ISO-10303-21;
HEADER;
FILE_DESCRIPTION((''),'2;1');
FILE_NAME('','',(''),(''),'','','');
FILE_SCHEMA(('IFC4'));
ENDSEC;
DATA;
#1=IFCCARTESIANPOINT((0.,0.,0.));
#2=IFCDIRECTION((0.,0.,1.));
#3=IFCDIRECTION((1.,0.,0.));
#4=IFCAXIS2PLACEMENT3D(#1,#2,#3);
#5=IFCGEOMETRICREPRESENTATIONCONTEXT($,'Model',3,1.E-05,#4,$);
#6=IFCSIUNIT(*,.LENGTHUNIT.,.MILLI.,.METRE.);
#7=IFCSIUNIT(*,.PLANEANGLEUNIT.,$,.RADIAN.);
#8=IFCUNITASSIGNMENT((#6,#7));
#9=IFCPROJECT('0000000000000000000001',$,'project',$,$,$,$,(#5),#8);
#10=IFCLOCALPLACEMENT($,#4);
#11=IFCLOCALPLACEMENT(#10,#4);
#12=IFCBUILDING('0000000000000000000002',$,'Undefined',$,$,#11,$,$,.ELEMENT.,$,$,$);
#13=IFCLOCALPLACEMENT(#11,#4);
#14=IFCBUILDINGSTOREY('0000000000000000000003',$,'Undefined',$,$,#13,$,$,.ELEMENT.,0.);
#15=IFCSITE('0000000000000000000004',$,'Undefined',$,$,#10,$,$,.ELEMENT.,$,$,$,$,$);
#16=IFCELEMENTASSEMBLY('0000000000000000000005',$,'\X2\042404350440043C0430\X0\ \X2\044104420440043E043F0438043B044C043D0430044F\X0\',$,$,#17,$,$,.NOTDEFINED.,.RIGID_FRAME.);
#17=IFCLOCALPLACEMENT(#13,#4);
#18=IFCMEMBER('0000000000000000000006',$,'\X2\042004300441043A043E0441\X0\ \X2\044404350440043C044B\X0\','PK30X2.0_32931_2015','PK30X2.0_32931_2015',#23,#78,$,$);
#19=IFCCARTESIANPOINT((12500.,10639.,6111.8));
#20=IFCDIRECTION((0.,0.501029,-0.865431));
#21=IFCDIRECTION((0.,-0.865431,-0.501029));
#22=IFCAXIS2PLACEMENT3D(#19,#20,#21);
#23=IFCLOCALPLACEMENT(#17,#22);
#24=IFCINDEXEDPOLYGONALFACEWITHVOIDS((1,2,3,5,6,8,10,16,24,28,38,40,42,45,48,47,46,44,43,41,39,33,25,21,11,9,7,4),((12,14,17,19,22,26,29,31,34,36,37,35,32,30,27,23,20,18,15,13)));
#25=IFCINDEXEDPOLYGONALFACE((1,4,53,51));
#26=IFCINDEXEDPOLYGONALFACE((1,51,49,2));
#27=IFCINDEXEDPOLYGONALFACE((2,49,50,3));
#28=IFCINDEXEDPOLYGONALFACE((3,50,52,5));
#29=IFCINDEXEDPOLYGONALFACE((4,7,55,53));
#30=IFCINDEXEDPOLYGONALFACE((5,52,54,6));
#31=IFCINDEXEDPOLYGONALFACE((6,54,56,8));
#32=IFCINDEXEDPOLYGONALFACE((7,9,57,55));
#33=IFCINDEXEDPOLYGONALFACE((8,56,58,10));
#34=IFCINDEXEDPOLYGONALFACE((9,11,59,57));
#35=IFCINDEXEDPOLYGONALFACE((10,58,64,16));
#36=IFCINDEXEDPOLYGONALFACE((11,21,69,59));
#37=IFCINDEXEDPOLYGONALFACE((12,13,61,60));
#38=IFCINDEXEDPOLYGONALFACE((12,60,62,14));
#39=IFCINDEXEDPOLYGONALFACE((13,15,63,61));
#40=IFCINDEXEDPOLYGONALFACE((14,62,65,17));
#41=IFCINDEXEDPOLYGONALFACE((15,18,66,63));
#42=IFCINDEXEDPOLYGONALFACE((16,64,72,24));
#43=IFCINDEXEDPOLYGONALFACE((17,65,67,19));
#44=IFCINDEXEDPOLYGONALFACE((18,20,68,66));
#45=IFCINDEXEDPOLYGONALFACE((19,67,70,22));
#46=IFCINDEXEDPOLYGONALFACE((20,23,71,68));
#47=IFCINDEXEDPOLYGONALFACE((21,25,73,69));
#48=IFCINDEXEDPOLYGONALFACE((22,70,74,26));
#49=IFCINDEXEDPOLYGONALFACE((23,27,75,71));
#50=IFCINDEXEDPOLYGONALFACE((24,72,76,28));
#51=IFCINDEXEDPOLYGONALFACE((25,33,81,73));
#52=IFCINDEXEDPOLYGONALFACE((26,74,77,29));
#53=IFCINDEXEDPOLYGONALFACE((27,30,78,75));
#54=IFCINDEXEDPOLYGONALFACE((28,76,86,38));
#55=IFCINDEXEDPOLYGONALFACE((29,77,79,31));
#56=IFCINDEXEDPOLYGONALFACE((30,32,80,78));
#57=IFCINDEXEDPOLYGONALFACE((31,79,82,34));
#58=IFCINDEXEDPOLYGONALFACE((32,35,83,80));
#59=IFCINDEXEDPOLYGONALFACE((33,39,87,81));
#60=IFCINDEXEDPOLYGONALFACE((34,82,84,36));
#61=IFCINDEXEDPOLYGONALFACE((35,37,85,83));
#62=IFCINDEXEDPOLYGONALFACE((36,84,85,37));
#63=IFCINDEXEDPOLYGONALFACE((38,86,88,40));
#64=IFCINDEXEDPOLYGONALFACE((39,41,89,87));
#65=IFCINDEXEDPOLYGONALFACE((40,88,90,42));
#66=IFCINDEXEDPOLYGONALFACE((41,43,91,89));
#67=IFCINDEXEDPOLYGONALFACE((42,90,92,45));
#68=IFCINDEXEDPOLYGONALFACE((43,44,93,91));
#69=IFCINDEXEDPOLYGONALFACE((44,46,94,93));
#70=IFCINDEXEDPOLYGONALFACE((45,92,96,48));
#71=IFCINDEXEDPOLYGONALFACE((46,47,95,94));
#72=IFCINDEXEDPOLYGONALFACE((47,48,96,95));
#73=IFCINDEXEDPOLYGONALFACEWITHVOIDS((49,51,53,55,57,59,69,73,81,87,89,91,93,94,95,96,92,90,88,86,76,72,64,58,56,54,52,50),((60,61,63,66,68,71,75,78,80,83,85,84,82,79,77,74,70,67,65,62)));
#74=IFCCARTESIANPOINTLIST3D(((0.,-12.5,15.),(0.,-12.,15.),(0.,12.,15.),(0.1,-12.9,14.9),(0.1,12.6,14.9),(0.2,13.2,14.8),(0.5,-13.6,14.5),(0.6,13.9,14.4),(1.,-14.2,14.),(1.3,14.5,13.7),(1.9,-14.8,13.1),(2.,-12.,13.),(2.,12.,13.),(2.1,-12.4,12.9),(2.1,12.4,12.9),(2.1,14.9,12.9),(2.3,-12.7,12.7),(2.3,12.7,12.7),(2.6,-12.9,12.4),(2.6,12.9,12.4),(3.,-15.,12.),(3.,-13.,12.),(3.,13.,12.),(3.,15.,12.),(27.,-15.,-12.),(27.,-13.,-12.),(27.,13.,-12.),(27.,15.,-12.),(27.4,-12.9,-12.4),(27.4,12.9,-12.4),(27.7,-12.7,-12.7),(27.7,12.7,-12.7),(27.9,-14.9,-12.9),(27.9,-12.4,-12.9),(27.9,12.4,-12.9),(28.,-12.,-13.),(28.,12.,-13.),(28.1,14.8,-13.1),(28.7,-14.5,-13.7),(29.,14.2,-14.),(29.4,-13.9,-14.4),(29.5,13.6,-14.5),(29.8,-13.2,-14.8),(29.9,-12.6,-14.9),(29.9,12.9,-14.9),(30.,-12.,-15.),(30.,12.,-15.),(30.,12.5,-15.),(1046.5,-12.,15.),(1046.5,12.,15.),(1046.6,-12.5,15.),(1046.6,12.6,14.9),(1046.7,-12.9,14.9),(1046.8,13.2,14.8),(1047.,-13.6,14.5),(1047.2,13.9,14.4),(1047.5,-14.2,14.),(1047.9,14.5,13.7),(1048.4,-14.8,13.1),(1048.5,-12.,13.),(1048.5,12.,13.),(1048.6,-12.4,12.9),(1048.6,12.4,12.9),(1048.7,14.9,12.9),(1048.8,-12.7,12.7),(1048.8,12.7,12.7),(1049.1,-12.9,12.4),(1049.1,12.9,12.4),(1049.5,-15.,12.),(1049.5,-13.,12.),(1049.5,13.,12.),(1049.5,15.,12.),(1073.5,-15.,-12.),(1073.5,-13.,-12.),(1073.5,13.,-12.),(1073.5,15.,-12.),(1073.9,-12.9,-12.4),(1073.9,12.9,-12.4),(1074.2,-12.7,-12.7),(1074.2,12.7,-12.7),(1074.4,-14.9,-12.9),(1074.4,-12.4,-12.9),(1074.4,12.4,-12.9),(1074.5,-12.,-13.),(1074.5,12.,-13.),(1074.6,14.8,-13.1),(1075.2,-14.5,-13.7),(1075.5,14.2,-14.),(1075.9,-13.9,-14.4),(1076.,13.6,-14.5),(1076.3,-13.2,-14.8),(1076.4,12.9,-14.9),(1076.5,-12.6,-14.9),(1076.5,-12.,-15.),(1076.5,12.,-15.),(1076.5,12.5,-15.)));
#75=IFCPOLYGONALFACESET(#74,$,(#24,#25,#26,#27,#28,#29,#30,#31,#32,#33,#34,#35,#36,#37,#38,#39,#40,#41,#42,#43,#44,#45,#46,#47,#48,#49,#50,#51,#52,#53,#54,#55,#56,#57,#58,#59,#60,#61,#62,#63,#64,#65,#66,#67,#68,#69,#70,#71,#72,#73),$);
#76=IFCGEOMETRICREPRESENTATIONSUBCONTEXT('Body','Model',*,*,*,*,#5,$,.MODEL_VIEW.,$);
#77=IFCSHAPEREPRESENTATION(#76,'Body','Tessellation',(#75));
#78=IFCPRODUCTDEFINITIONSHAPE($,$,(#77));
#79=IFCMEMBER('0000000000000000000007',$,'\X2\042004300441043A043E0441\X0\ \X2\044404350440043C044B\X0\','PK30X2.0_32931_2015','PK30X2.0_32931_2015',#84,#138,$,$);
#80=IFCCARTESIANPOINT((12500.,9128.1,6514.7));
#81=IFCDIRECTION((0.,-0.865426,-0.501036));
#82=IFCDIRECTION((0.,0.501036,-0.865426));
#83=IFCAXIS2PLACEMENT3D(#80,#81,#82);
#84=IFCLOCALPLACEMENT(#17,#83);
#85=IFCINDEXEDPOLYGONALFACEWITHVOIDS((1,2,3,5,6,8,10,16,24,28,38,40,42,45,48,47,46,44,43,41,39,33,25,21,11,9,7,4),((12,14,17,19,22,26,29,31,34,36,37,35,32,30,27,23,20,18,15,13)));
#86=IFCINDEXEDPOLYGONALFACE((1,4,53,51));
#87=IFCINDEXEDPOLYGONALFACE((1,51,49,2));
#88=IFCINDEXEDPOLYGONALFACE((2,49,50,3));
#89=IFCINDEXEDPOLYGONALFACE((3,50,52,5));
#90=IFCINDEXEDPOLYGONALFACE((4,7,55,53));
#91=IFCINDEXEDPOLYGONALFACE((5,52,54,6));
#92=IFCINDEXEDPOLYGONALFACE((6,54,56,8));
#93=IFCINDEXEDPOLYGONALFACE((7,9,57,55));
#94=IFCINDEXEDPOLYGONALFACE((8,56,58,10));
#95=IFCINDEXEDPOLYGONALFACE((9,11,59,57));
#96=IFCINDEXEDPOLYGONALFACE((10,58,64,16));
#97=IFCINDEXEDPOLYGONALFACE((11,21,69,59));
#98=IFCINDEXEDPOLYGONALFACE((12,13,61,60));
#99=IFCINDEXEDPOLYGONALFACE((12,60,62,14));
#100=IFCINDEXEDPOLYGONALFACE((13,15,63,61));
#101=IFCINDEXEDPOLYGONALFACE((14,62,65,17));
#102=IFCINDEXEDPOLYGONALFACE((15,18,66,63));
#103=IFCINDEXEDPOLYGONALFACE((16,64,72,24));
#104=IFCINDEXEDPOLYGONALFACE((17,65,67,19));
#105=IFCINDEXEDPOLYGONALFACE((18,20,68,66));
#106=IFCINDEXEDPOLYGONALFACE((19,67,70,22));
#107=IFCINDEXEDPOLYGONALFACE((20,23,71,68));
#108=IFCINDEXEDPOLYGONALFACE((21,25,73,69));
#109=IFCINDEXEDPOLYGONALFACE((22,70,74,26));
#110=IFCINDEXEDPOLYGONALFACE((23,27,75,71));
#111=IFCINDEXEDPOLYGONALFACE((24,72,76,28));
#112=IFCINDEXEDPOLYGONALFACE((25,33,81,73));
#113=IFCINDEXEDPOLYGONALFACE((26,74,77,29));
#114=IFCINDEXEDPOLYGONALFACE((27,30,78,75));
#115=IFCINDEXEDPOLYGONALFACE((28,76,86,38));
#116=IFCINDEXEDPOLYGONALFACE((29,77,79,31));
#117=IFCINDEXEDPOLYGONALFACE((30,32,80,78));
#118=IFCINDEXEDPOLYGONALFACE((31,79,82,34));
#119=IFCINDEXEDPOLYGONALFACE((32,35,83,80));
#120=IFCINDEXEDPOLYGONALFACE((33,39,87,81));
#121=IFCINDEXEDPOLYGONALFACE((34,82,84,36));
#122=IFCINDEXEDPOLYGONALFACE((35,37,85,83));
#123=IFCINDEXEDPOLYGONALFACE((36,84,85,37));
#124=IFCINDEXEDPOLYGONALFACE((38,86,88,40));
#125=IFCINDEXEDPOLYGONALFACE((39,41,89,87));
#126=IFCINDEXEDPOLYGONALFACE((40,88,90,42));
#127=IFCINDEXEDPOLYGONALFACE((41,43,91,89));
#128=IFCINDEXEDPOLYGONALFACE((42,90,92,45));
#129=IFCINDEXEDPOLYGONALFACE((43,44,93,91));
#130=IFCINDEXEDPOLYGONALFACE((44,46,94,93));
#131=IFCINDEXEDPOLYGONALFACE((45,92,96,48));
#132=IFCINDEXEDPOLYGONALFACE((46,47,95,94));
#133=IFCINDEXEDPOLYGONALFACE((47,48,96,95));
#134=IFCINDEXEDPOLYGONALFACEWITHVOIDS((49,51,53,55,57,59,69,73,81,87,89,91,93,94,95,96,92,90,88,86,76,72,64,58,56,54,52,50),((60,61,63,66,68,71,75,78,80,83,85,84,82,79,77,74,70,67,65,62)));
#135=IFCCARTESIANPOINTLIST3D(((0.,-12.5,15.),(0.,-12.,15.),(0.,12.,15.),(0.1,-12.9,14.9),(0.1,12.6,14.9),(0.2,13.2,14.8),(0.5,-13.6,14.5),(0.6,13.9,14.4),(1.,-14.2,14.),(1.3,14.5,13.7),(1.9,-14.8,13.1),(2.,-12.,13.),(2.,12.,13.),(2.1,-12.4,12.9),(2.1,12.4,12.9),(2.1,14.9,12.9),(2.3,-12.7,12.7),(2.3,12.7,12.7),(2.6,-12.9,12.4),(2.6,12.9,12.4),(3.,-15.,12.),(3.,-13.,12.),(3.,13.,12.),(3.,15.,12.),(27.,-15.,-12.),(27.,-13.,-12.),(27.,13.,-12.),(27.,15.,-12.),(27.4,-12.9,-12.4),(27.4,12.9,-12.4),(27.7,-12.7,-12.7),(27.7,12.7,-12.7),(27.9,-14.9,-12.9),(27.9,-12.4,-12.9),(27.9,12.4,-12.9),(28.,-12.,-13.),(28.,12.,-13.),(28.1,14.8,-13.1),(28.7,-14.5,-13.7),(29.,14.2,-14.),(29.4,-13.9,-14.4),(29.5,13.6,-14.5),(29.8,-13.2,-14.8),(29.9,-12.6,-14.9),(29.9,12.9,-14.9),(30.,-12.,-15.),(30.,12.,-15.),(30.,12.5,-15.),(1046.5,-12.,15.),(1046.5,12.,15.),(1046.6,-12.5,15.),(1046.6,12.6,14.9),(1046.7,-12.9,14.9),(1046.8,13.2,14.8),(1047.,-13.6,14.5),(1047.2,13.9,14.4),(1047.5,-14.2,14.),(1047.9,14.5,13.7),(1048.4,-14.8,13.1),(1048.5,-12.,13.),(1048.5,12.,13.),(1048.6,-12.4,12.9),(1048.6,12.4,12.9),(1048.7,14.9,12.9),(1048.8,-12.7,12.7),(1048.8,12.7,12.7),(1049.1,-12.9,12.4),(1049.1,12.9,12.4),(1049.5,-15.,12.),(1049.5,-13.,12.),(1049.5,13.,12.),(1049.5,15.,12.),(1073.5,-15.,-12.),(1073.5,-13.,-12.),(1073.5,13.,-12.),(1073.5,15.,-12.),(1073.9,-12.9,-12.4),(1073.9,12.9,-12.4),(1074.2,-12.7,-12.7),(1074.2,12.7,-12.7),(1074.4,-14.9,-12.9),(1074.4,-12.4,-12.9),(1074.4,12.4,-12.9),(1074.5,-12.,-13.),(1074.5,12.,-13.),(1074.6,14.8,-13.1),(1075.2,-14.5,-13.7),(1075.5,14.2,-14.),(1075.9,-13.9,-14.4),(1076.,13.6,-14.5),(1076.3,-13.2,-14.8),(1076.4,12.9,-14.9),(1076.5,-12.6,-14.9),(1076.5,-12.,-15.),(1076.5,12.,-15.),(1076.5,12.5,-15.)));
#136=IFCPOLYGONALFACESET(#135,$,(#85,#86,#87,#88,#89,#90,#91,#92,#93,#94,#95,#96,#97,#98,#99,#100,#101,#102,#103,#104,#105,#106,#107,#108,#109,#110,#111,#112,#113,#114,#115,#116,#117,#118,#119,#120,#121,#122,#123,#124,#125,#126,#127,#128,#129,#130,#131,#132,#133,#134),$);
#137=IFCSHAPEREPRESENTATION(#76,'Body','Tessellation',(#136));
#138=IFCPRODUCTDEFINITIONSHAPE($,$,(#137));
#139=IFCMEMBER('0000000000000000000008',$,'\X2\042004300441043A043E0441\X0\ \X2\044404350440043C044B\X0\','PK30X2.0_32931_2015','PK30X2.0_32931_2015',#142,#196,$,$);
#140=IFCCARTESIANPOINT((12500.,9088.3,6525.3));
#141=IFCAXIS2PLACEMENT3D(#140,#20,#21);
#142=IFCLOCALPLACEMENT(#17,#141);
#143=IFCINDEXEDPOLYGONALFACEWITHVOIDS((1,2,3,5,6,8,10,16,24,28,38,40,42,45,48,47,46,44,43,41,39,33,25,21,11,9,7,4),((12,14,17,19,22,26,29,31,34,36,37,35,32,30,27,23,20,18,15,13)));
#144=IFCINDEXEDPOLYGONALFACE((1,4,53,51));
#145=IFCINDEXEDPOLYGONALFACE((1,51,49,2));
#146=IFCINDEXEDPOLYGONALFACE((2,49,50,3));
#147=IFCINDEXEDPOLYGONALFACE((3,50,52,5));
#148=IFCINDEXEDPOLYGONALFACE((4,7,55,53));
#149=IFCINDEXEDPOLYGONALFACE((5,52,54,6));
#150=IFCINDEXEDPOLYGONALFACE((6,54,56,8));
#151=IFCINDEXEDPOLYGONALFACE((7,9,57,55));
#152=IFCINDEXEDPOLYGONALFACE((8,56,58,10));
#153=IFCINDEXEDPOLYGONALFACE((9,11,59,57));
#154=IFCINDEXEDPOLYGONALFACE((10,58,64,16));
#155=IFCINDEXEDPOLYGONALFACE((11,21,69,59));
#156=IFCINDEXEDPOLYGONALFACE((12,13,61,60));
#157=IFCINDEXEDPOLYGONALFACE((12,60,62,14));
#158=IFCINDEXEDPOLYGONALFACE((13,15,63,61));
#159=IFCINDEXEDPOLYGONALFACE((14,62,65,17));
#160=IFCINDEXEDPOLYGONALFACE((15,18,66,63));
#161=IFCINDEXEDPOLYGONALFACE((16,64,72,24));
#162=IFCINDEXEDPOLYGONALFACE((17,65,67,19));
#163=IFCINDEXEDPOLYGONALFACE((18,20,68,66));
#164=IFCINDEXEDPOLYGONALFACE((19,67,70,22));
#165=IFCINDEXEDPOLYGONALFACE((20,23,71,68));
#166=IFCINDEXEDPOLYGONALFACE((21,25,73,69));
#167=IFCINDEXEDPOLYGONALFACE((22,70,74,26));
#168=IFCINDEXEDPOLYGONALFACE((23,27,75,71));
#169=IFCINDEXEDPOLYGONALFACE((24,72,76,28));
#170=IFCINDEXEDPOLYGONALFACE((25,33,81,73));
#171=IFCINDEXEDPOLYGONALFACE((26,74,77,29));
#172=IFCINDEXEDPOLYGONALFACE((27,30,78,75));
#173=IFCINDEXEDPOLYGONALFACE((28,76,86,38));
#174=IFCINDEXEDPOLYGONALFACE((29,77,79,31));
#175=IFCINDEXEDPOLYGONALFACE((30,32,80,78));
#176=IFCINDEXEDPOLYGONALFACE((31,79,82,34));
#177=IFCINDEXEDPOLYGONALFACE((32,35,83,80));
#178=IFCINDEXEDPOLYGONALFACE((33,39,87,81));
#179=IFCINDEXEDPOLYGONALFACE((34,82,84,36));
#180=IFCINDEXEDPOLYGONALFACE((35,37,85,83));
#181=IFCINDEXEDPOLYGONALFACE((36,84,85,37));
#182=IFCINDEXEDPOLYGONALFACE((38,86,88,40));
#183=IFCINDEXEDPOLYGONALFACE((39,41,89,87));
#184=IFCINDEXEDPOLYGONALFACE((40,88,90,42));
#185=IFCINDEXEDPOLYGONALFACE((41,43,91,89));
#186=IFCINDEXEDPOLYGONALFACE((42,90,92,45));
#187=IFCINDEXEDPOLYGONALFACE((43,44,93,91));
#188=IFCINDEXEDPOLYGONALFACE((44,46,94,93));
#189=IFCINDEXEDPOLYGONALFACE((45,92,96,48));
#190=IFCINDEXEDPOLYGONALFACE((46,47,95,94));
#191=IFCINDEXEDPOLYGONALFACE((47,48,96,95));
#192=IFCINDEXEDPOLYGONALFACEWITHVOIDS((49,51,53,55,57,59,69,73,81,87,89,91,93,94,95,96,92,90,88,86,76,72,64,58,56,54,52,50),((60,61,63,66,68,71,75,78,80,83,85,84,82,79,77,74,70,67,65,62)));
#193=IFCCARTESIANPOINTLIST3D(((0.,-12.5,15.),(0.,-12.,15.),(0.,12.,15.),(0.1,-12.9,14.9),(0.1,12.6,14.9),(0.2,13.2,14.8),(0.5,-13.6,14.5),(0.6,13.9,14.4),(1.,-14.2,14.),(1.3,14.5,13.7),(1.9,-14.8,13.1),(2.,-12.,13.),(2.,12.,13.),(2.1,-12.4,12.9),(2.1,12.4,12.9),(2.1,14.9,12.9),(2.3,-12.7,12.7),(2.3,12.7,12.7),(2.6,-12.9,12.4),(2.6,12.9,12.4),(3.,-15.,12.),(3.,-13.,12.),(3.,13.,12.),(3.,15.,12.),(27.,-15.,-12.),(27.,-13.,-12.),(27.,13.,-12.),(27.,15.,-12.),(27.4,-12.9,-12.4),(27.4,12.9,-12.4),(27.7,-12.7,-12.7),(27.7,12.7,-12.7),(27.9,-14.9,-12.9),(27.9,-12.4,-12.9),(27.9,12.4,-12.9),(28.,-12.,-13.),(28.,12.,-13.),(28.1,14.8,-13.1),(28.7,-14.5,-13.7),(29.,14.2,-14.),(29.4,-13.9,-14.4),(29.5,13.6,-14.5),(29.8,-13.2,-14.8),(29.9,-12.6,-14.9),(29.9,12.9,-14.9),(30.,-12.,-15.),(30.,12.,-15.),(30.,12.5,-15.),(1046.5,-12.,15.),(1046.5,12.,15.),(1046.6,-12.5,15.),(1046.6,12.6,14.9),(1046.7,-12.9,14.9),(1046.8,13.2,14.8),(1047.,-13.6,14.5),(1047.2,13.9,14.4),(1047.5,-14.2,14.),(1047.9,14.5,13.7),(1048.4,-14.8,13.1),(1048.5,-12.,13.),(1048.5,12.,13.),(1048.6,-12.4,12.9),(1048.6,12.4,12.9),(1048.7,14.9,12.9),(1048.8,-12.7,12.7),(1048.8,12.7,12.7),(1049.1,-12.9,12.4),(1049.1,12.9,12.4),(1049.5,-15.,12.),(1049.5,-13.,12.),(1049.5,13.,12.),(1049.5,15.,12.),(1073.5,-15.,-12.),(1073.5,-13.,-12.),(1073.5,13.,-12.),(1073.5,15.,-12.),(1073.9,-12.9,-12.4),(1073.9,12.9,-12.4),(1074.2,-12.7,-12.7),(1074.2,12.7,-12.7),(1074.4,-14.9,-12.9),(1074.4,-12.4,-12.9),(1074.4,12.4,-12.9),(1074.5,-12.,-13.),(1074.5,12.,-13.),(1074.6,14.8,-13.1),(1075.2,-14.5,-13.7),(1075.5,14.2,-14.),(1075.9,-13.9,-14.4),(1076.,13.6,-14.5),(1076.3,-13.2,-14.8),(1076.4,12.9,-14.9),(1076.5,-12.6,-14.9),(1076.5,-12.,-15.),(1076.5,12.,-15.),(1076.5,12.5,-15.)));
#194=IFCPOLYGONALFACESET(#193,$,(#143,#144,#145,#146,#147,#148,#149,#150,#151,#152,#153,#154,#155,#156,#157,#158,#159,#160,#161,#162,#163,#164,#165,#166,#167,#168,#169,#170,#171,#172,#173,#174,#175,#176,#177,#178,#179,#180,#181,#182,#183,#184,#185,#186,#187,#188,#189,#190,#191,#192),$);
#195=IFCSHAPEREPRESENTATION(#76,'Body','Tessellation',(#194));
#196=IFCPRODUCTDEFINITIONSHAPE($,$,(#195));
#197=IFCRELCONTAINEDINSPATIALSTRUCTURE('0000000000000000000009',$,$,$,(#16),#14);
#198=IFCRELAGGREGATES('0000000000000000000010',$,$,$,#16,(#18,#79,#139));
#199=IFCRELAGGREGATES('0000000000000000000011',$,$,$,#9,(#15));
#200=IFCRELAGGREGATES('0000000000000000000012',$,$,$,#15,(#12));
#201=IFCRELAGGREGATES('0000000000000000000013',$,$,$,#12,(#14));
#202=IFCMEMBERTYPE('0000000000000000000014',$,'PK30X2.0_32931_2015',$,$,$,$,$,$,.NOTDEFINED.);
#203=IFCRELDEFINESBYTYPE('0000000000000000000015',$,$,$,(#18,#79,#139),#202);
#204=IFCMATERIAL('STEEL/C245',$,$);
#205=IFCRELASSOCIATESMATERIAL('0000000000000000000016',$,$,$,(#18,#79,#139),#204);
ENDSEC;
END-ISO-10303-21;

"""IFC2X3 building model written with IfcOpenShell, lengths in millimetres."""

from ifc_helpers import new_model, si_unit, frame, origin_with_axes, origin_2d_with_axis, place, context, subcontext, project, spatial, hollow_rectangle, extrude, clip, halfspace, material, type_object, element, aggregate, save


model = new_model("IFC2X3")

# Units and contexts
model_context = context("Model", 3, precision=1e-05, world=origin_with_axes())
body_context = subcontext(model_context, "Body", "Model", "MODEL_VIEW")
ifc_project = project(units=[si_unit("LENGTHUNIT", "METRE", prefix="MILLI"), si_unit("PLANEANGLEUNIT", "RADIAN")], contexts=[model_context])

# Site, building, storey
site_placement = place(None, origin_with_axes())
site = spatial("IfcSite", under=ifc_project, at=site_placement, Name="Undefined", CompositionType="ELEMENT")
building_placement = place(site_placement, origin_with_axes())
building = spatial("IfcBuilding", under=site, at=building_placement, Name="Undefined", CompositionType="ELEMENT")
storey_placement = place(building_placement, origin_with_axes())
storey = spatial("IfcBuildingStorey", under=building, at=storey_placement, Name="Undefined", CompositionType="ELEMENT", Elevation=0.0)

# Shared definitions
ifc_material_1 = material(Name="STEEL/C245")

# Shared definitions
member_type = type_object("IfcMemberType", Name="PK30X2.0_32931_2015", PredefinedType="NOTDEFINED")

# Element assembly, members
assembly_1_placement = place(storey_placement, origin_with_axes())
assembly_1 = element("IfcElementAssembly", 1, at=assembly_1_placement, inside=storey, Name="Ферма стропильная", AssemblyPlace="NOTDEFINED", PredefinedType="RIGID_FRAME")
member_1_placement = place(assembly_1_placement, frame((12500.0, 10639.0, 6111.8), z_axis=(0.0, 0.501029, -0.865431), x_axis=(0.0, -0.865431, -0.501029)))
member_1 = element("IfcMember", 2, at=member_1_placement, type_object=member_type, material=ifc_material_1, Name="Раскос фермы", Description="PK30X2.0_32931_2015", ObjectType="PK30X2.0_32931_2015", context=body_context, shape_type="Clipping", body=[
    clip(clip(extrude(hollow_rectangle(XDim=30.0, YDim=30.0, WallThickness=2.0, InnerFilletRadius=1.0, OuterFilletRadius=3.0, at=origin_2d_with_axis()), frame((1102.9, 0.0, 0.0), z_axis=(-1.0, 0.0, 0.0), x_axis=(0.0, -1.0, 0.0)), (0.0, 0.0, 1.0), 1129.2), halfspace(frame((1060.0, 0.0, 1.5), z_axis=(-0.707107, 0.0, -0.707107), x_axis=(0.707107, 0.0, -0.707107)), True)), halfspace(frame((34.5, 0.0, -19.5), z_axis=(-0.707107, 0.0, -0.707107), x_axis=(0.707107, 0.0, -0.707107)), False)),
])
member_2_placement = place(assembly_1_placement, frame((12500.0, 9128.1, 6514.7), z_axis=(0.0, -0.865426, -0.501036), x_axis=(0.0, 0.501036, -0.865426)))
member_2 = element("IfcMember", 3, at=member_2_placement, type_object=member_type, material=ifc_material_1, Name="Раскос фермы", Description="PK30X2.0_32931_2015", ObjectType="PK30X2.0_32931_2015", context=body_context, shape_type="Clipping", body=[
    clip(clip(extrude(hollow_rectangle(XDim=30.0, YDim=30.0, WallThickness=2.0, InnerFilletRadius=1.0, OuterFilletRadius=3.0, at=origin_2d_with_axis()), frame((1091.8, 0.0, 0.0), z_axis=(-1.0, 0.0, 0.0), x_axis=(0.0, -1.0, 0.0)), (0.0, 0.0, 1.0), 1107.1), halfspace(frame((1060.0, 0.0, 1.5), z_axis=(-0.707107, 0.0, -0.707107), x_axis=(0.707107, 0.0, -0.707107)), True)), halfspace(frame((34.5, 0.0, -19.5), z_axis=(-0.707107, 0.0, -0.707107), x_axis=(0.707107, 0.0, -0.707107)), False)),
])
member_3_placement = place(assembly_1_placement, frame((12500.0, 9088.3, 6525.3), z_axis=(0.0, 0.501029, -0.865431), x_axis=(0.0, -0.865431, -0.501029)))
member_3 = element("IfcMember", 4, at=member_3_placement, type_object=member_type, material=ifc_material_1, Name="Раскос фермы", Description="PK30X2.0_32931_2015", ObjectType="PK30X2.0_32931_2015", context=body_context, shape_type="Clipping", body=[
    clip(clip(extrude(hollow_rectangle(XDim=30.0, YDim=30.0, WallThickness=2.0, InnerFilletRadius=1.0, OuterFilletRadius=3.0, at=origin_2d_with_axis()), frame((1102.9, 0.0, 0.0), z_axis=(-1.0, 0.0, 0.0), x_axis=(0.0, -1.0, 0.0)), (0.0, 0.0, 1.0), 1129.2), halfspace(frame((1060.0, 0.0, 1.5), z_axis=(-0.707107, 0.0, -0.707107), x_axis=(0.707107, 0.0, -0.707107)), True)), halfspace(frame((34.5, 0.0, -19.5), z_axis=(-0.707107, 0.0, -0.707107), x_axis=(0.707107, 0.0, -0.707107)), False)),
])
aggregate(assembly_1, [member_1, member_2, member_3])

save(model, "model.ifc")
